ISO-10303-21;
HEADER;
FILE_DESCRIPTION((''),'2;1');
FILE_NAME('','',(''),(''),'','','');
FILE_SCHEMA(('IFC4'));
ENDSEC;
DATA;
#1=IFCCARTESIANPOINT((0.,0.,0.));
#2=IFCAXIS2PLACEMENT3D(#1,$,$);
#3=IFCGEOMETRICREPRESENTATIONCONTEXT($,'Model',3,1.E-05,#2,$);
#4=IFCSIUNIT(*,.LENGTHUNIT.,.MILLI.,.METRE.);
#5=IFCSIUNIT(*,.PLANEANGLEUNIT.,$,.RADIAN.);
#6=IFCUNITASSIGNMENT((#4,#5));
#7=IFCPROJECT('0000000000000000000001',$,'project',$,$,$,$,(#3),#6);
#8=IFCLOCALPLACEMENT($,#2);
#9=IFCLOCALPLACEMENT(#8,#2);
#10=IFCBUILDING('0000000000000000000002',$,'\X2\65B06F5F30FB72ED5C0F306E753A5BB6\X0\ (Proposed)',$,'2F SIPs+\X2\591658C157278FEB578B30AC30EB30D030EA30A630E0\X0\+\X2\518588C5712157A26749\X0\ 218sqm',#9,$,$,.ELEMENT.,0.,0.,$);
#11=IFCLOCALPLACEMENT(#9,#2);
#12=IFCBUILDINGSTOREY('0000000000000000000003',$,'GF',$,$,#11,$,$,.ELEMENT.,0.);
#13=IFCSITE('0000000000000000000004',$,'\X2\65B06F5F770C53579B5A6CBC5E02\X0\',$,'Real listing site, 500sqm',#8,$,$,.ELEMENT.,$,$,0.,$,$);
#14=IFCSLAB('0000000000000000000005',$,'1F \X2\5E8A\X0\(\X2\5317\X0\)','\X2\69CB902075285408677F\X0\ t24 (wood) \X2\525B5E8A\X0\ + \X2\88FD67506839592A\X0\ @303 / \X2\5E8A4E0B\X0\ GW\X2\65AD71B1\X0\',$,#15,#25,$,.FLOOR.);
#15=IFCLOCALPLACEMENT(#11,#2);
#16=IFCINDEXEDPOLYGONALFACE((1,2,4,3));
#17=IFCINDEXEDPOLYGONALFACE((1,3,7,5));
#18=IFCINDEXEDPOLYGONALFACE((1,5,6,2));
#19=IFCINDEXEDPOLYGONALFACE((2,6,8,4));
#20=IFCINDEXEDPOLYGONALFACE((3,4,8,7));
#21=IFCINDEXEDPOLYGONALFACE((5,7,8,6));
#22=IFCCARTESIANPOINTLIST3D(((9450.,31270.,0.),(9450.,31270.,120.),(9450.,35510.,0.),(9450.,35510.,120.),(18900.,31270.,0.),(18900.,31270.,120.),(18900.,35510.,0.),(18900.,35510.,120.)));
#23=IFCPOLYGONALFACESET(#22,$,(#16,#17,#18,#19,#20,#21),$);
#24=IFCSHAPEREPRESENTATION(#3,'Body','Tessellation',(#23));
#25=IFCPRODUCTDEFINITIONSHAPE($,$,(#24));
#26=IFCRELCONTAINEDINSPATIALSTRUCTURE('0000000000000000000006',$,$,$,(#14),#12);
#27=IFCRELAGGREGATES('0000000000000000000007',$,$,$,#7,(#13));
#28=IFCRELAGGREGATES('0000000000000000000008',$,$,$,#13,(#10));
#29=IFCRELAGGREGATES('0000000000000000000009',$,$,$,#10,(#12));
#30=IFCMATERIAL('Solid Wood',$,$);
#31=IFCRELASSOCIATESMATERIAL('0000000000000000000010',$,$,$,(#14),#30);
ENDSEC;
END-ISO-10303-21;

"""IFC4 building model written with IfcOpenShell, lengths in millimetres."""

from ifc_helpers import new_model, si_unit, frame, frame_2d, origin, place, context, project, spatial, rectangle, extrude, material, element, save


model = new_model("IFC4")

# Units and contexts
model_context = context("Model", 3, precision=1e-05, world=origin())
ifc_project = project(units=[si_unit("LENGTHUNIT", "METRE", prefix="MILLI"), si_unit("PLANEANGLEUNIT", "RADIAN")], contexts=[model_context])

# Site, building, storey
site_placement = place(None, origin())
site = spatial("IfcSite", under=ifc_project, at=site_placement, Name="新潟県南魚沼市", ObjectType="Real listing site, 500sqm", CompositionType="ELEMENT", RefElevation=0.0)
building_placement = place(site_placement, origin())
building = spatial("IfcBuilding", under=site, at=building_placement, Name="新潟・狭小の町家 (Proposed)", ObjectType="2F SIPs+外壁圧迫型ガルバリウム+内装無垢杉 218sqm", CompositionType="ELEMENT", ElevationOfRefHeight=0.0, ElevationOfTerrain=0.0)
storey_placement = place(building_placement, origin())
storey = spatial("IfcBuildingStorey", under=building, at=storey_placement, Name="GF", CompositionType="ELEMENT", Elevation=0.0)

# Shared definitions
ifc_material_1 = material(Name="Solid Wood")

# Slab
slab_1_placement = place(storey_placement, frame((4725.0, 15635.0, 0.0)))
element("IfcSlab", 1, at=slab_1_placement, inside=storey, material=ifc_material_1, Name="1F 床(北)", Description="構造用合板 t24 (wood) 剛床 + 製材根太 @303 / 床下 GW断熱", PredefinedType="FLOOR", context=model_context, shape_type="SweptSolid", body=[
    extrude(rectangle(XDim=9450.0, YDim=4240.0, at=frame_2d((4725.0, 2120.0))), frame((4725.0, 15635.0, 0.0)), (0.0, 0.0, 1.0), 120.0),
])

save(model, "model.ifc")
